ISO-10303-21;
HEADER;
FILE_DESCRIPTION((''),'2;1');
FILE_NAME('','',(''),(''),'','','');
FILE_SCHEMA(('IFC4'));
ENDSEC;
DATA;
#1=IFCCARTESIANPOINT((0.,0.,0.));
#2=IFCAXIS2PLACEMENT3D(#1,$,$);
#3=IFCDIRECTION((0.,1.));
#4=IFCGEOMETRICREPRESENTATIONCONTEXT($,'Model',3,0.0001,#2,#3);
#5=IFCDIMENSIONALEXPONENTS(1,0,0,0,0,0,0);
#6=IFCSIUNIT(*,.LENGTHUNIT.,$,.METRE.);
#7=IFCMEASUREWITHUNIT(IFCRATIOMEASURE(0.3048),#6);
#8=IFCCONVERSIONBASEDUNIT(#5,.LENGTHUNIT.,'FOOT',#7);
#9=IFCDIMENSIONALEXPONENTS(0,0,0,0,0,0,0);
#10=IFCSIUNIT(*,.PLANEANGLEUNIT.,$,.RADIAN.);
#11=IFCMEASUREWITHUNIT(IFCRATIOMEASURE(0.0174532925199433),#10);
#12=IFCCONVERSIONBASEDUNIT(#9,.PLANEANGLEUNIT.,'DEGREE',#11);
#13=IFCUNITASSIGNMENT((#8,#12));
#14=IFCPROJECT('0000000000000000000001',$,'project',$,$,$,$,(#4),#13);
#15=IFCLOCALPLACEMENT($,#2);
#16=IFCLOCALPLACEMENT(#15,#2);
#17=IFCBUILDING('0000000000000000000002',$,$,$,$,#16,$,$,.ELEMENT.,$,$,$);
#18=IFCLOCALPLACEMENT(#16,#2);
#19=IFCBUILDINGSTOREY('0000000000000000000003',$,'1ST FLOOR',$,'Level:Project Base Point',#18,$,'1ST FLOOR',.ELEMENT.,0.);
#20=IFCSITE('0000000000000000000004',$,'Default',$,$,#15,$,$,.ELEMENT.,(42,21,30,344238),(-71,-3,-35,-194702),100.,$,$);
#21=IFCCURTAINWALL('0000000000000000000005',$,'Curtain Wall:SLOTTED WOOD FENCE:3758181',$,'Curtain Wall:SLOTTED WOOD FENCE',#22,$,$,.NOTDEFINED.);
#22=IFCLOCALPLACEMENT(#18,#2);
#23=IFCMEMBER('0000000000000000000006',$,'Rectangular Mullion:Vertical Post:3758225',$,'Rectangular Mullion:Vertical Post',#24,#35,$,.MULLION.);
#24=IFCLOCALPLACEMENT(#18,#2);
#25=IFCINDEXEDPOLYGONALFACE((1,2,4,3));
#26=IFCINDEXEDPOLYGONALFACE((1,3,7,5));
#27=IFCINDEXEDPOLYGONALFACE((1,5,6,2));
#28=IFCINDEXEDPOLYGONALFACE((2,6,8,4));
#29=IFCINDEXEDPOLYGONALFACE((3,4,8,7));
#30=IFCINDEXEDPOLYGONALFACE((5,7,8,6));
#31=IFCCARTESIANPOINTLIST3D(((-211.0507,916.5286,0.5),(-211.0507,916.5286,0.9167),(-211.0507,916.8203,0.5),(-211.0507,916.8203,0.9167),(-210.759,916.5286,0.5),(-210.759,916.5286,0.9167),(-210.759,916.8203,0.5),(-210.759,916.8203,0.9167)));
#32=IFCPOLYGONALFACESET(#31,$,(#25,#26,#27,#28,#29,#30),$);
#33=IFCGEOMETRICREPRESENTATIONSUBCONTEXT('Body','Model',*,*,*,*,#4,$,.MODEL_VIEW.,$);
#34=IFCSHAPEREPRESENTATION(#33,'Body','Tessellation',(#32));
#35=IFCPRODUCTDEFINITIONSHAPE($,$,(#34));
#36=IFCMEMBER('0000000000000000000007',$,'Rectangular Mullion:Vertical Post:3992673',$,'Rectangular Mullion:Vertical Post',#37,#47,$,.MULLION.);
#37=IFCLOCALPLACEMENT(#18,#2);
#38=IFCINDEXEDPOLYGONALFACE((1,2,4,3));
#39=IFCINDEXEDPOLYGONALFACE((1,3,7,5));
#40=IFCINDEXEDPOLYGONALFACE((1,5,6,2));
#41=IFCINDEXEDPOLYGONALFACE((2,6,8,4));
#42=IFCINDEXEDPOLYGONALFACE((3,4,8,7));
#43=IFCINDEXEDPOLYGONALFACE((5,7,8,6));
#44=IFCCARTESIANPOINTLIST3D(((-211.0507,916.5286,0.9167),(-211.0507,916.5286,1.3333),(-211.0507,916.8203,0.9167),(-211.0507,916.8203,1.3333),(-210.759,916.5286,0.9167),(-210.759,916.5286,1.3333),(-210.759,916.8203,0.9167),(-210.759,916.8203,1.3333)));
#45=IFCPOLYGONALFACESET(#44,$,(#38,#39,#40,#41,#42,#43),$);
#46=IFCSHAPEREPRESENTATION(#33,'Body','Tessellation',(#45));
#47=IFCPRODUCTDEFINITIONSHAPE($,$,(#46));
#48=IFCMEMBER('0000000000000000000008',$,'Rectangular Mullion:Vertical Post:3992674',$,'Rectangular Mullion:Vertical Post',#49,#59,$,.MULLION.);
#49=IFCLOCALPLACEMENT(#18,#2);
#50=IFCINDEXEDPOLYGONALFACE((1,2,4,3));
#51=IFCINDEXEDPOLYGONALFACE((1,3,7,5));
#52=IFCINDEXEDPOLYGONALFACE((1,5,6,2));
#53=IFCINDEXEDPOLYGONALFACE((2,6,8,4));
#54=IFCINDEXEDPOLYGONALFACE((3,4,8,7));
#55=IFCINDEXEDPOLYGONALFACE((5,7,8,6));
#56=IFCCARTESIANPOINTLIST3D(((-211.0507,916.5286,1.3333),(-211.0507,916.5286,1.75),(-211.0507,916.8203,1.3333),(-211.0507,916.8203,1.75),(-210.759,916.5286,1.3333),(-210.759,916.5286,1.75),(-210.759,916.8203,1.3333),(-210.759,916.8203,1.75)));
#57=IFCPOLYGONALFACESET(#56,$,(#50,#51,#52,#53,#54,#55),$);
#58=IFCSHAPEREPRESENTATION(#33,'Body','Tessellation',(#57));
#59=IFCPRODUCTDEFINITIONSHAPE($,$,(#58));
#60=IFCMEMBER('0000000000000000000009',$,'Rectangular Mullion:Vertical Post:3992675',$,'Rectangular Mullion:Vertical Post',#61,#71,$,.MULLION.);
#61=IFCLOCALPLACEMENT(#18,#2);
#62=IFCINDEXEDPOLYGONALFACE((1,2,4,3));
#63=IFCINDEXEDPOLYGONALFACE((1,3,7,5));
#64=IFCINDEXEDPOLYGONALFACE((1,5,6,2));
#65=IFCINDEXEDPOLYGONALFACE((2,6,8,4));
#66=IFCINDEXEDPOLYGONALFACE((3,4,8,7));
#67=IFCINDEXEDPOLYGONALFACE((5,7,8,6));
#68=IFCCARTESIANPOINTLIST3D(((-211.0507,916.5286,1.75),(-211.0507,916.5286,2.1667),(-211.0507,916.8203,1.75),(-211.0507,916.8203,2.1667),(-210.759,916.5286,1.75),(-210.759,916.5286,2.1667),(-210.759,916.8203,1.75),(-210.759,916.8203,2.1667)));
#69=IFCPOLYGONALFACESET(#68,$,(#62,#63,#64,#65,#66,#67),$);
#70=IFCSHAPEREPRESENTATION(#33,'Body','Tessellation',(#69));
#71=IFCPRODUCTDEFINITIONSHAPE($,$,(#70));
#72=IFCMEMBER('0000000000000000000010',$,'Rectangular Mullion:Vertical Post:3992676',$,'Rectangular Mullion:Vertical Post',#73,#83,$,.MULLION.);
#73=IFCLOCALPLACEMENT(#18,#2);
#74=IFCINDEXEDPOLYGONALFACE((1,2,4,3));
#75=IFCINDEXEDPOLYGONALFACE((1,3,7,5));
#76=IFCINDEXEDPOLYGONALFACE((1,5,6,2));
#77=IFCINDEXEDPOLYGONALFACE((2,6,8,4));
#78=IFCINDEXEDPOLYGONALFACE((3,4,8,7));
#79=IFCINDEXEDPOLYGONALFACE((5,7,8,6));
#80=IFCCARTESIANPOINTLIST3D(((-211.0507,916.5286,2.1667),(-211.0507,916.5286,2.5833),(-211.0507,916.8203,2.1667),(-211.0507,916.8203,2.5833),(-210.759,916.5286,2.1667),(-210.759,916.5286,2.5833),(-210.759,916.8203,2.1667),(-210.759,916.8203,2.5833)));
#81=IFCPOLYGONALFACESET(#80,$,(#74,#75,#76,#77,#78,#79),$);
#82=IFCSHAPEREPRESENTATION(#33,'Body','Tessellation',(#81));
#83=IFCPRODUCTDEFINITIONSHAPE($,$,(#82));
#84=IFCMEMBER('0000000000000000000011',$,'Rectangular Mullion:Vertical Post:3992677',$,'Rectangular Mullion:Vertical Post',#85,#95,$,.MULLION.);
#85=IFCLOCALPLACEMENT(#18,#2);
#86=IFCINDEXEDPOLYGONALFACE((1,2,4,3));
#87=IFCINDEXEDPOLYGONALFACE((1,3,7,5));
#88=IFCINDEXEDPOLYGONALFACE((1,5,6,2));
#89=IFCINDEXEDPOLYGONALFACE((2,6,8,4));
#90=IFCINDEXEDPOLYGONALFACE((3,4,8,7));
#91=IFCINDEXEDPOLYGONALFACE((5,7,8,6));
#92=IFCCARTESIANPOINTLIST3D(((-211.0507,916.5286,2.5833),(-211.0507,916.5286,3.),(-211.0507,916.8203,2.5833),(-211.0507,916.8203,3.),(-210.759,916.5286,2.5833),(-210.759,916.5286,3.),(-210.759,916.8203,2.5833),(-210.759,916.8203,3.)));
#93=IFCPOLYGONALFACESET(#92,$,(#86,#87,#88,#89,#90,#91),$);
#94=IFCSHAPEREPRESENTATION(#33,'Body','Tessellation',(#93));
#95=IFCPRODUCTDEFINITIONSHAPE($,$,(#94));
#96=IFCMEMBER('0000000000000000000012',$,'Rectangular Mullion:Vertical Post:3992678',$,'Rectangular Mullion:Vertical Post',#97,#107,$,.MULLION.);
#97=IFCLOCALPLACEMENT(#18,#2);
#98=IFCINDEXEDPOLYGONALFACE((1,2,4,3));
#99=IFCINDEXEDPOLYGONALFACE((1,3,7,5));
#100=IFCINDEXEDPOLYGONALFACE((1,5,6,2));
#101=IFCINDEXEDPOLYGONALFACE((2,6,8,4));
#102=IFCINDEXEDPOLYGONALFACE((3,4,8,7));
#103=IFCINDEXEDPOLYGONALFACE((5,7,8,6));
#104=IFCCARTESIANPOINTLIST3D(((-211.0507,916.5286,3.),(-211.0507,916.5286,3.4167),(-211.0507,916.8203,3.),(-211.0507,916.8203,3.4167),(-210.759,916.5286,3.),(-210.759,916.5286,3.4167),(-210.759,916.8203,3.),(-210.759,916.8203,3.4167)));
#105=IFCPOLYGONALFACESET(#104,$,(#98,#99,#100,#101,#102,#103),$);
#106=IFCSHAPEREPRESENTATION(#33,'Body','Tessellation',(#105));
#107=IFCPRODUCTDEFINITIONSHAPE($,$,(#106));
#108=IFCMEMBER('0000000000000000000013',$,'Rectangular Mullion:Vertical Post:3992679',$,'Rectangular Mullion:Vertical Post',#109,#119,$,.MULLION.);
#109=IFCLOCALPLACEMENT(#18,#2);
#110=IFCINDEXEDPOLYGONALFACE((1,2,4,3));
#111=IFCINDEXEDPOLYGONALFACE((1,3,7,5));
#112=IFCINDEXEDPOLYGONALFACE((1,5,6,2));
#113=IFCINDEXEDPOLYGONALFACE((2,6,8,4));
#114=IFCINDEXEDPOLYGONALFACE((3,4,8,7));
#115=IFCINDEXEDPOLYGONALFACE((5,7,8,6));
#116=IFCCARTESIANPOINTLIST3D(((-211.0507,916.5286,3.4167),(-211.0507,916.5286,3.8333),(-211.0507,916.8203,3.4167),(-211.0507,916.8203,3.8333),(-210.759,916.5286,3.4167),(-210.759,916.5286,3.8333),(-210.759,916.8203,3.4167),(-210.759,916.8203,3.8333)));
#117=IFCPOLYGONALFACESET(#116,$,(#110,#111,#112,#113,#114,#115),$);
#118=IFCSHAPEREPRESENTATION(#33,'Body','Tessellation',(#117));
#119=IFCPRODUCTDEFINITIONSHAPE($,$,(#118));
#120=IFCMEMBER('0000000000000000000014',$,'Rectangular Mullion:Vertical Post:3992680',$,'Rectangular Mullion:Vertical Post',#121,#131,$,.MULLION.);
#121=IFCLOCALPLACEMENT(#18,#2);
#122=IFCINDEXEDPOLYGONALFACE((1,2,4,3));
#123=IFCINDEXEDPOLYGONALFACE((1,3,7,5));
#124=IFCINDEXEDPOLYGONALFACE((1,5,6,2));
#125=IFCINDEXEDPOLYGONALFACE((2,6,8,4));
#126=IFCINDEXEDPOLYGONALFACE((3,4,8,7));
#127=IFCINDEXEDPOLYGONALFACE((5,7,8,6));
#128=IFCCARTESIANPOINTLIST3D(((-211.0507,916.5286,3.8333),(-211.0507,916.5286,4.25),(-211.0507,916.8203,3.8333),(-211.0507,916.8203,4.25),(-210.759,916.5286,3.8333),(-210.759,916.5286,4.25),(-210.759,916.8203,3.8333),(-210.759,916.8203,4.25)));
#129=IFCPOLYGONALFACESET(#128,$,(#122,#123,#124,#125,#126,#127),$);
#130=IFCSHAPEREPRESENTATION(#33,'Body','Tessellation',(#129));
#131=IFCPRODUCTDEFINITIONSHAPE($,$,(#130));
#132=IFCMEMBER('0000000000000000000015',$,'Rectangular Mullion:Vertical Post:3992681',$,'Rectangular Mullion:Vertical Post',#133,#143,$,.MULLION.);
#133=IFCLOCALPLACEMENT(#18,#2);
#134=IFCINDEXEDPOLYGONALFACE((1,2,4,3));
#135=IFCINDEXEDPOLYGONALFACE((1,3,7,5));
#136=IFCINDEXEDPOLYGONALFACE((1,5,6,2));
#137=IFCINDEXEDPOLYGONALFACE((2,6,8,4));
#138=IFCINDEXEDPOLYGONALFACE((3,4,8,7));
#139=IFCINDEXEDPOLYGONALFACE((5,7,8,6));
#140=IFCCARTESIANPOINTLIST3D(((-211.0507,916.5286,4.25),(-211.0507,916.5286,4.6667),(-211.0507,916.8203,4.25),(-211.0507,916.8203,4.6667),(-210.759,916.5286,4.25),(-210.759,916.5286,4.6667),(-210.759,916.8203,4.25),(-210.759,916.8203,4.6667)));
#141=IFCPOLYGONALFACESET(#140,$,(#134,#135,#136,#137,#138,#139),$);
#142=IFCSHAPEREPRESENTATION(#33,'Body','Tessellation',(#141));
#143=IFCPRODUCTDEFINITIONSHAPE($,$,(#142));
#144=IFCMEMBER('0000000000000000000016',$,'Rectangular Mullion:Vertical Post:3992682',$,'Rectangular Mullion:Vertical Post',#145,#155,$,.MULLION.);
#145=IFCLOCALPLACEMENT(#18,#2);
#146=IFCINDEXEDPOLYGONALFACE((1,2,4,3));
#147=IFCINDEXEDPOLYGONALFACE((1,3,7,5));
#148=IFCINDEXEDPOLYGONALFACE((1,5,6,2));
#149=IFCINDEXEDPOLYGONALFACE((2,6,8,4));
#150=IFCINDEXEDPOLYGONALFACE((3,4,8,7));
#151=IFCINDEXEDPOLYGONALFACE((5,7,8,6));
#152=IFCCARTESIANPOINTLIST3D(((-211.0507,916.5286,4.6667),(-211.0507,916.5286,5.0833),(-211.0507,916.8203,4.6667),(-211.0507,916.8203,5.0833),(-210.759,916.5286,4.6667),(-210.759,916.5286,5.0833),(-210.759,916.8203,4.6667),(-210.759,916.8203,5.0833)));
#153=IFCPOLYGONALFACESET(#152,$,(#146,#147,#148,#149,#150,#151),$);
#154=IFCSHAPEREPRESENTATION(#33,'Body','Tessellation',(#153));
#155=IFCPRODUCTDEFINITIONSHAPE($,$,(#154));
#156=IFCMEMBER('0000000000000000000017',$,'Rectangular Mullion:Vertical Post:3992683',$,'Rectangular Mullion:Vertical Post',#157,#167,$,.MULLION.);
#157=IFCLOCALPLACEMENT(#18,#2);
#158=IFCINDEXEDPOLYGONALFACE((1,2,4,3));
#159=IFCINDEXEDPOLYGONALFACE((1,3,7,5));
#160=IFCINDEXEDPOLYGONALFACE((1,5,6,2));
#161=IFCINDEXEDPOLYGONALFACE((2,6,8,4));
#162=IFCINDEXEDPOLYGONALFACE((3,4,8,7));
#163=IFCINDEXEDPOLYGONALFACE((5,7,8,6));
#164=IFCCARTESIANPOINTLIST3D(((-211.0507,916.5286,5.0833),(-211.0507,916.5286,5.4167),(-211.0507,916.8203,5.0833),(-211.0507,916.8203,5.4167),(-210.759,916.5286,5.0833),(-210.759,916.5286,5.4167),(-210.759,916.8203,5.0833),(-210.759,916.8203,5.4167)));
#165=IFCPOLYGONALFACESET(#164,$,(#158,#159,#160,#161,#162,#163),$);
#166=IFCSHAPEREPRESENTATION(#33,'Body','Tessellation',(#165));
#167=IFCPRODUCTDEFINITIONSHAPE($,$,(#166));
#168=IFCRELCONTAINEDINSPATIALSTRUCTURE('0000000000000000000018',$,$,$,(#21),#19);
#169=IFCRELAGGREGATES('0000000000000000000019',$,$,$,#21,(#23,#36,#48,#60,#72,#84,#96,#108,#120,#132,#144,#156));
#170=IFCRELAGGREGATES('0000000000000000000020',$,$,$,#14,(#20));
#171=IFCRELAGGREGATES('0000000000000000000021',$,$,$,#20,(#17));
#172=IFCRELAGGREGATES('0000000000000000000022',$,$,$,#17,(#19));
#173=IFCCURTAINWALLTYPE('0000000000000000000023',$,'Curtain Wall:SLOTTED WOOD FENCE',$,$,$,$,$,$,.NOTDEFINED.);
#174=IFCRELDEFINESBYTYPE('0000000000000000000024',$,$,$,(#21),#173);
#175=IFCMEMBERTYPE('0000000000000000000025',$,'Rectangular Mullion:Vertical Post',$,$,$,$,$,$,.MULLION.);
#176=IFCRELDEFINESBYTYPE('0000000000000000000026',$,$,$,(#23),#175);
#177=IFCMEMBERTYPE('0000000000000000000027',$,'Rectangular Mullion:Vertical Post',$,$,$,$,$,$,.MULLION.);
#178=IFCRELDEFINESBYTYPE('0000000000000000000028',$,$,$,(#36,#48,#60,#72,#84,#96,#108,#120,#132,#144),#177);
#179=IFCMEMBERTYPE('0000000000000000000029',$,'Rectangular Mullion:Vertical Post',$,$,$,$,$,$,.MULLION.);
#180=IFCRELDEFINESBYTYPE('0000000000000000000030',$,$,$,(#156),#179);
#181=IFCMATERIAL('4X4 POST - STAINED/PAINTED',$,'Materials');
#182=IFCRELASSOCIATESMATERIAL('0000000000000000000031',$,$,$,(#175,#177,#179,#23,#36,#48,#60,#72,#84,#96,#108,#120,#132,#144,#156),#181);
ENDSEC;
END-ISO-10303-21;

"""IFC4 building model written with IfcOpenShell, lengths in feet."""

from ifc_helpers import new_model, entity, si_unit, converted_unit, direction, frame, origin, origin_2d_with_axis, place, context, subcontext, project, spatial, rectangle, extrude, source, transform, mapped, material, material_profile, profile_set, profile_usage, type_object, type_shapes, element, aggregate, save


model = new_model("IFC4")

# Units and contexts
model_context = context("Model", 3, precision=0.0001, world=origin(), true_north=direction((0.0, 1.0)))
body_context = subcontext(model_context, "Body", "Model", "MODEL_VIEW")
ifc_project = project(units=[converted_unit("LENGTHUNIT", "FOOT", entity("IfcRatioMeasure", 0.3048), si_unit("LENGTHUNIT", "METRE"), dimensions=[1, 0, 0, 0, 0, 0, 0]), converted_unit("PLANEANGLEUNIT", "DEGREE", entity("IfcRatioMeasure", 0.0174532925199433), si_unit("PLANEANGLEUNIT", "RADIAN"), dimensions=[0, 0, 0, 0, 0, 0, 0])], contexts=[model_context])

# Site, building, storey
site_placement = place(None, origin())
site = spatial("IfcSite", under=ifc_project, at=site_placement, Name="Default", CompositionType="ELEMENT", RefLatitude=(42, 21, 30, 344238), RefLongitude=(-71, -3, -35, -194702), RefElevation=100.0)
building_placement = place(site_placement, origin())
building = spatial("IfcBuilding", under=site, at=building_placement, CompositionType="ELEMENT")
storey_placement = place(building_placement, origin())
storey = spatial("IfcBuildingStorey", under=building, at=storey_placement, Name="1ST FLOOR", ObjectType="Level:Project Base Point", LongName="1ST FLOOR", CompositionType="ELEMENT", Elevation=0.0)

# Curtain wall, members
curtain_wall_type = type_object("IfcCurtainWallType", Name="Curtain Wall:SLOTTED WOOD FENCE", PredefinedType="NOTDEFINED")
curtain_wall_placement = place(storey_placement, origin())
curtain_wall = element("IfcCurtainWall", 1, at=curtain_wall_placement, inside=storey, type_object=curtain_wall_type, Name="Curtain Wall:SLOTTED WOOD FENCE:3758181", ObjectType="Curtain Wall:SLOTTED WOOD FENCE", PredefinedType="NOTDEFINED")
ifc_material_1 = material(Name="4X4 POST - STAINED/PAINTED", Category="Materials")
ifc_material_profile = material_profile(ifc_material_1, rectangle(XDim=0.2917, YDim=0.2917, at=origin_2d_with_axis()), Name="Vertical Post")
ifc_profile_set = profile_set([ifc_material_profile], Name="Vertical Post")
ifc_profile_usage_1 = profile_usage(ifc_profile_set)
member_type_1 = type_object("IfcMemberType", Name="Rectangular Mullion:Vertical Post", PredefinedType="MULLION", material=ifc_profile_set)
shared_shape_1 = source(origin(), body_context, "Body", "SweptSolid", [
    extrude(rectangle(XDim=0.2917, YDim=0.2917, at=origin_2d_with_axis()), frame((0.0, -0.2083, -0.4167), z_axis=(0.0, 0.0, 1.0), x_axis=(0.0, -1.0, 0.0)), (0.0, 0.0, 1.0), 0.4167),
])
type_shapes(member_type_1, [shared_shape_1])
member_1_placement = place(storey_placement, frame((-210.9048, 916.4661, 0.5), z_axis=(0.0, 0.0, -1.0), x_axis=(1.0, 0.0, 0.0)))
member_1 = element("IfcMember", 2, at=member_1_placement, type_object=member_type_1, material=ifc_profile_usage_1, Name="Rectangular Mullion:Vertical Post:3758225", ObjectType="Rectangular Mullion:Vertical Post", PredefinedType="MULLION", context=body_context, shape_type="MappedRepresentation", body=[
    mapped(shared_shape_1, transform((0.0, 0.0, 0.0), scale=1.0)),
])
ifc_profile_usage_2 = profile_usage(ifc_profile_set)
member_type_2 = type_object("IfcMemberType", Name="Rectangular Mullion:Vertical Post", PredefinedType="MULLION", material=ifc_profile_set)
shared_shape_2 = source(origin(), body_context, "Body", "SweptSolid", [
    extrude(rectangle(XDim=0.2917, YDim=0.2917, at=origin_2d_with_axis()), frame((0.0, -0.2083, -0.4167), z_axis=(0.0, 0.0, 1.0), x_axis=(0.0, -1.0, 0.0)), (0.0, 0.0, 1.0), 0.4167),
])
type_shapes(member_type_2, [shared_shape_2])
member_2_placement = place(storey_placement, frame((-210.9048, 916.4661, 0.9167), z_axis=(0.0, 0.0, -1.0), x_axis=(1.0, 0.0, 0.0)))
member_2 = element("IfcMember", 3, at=member_2_placement, type_object=member_type_2, material=ifc_profile_usage_2, Name="Rectangular Mullion:Vertical Post:3992673", ObjectType="Rectangular Mullion:Vertical Post", PredefinedType="MULLION", context=body_context, shape_type="MappedRepresentation", body=[
    mapped(shared_shape_2, transform((0.0, 0.0, 0.0), scale=1.0)),
])
ifc_profile_usage_3 = profile_usage(ifc_profile_set)
member_3_placement = place(storey_placement, frame((-210.9048, 916.4661, 1.3333), z_axis=(0.0, 0.0, -1.0), x_axis=(1.0, 0.0, 0.0)))
member_3 = element("IfcMember", 4, at=member_3_placement, type_object=member_type_2, material=ifc_profile_usage_3, Name="Rectangular Mullion:Vertical Post:3992674", ObjectType="Rectangular Mullion:Vertical Post", PredefinedType="MULLION", context=body_context, shape_type="MappedRepresentation", body=[
    mapped(shared_shape_2, transform((0.0, 0.0, 0.0), scale=1.0)),
])
ifc_profile_usage_4 = profile_usage(ifc_profile_set)
member_4_placement = place(storey_placement, frame((-210.9048, 916.4661, 1.75), z_axis=(0.0, 0.0, -1.0), x_axis=(1.0, 0.0, 0.0)))
member_4 = element("IfcMember", 5, at=member_4_placement, type_object=member_type_2, material=ifc_profile_usage_4, Name="Rectangular Mullion:Vertical Post:3992675", ObjectType="Rectangular Mullion:Vertical Post", PredefinedType="MULLION", context=body_context, shape_type="MappedRepresentation", body=[
    mapped(shared_shape_2, transform((0.0, 0.0, 0.0), scale=1.0)),
])
ifc_profile_usage_5 = profile_usage(ifc_profile_set)
member_5_placement = place(storey_placement, frame((-210.9048, 916.4661, 2.1667), z_axis=(0.0, 0.0, -1.0), x_axis=(1.0, 0.0, 0.0)))
member_5 = element("IfcMember", 6, at=member_5_placement, type_object=member_type_2, material=ifc_profile_usage_5, Name="Rectangular Mullion:Vertical Post:3992676", ObjectType="Rectangular Mullion:Vertical Post", PredefinedType="MULLION", context=body_context, shape_type="MappedRepresentation", body=[
    mapped(shared_shape_2, transform((0.0, 0.0, 0.0), scale=1.0)),
])
ifc_profile_usage_6 = profile_usage(ifc_profile_set)
member_6_placement = place(storey_placement, frame((-210.9048, 916.4661, 2.5833), z_axis=(0.0, 0.0, -1.0), x_axis=(1.0, 0.0, 0.0)))
member_6 = element("IfcMember", 7, at=member_6_placement, type_object=member_type_2, material=ifc_profile_usage_6, Name="Rectangular Mullion:Vertical Post:3992677", ObjectType="Rectangular Mullion:Vertical Post", PredefinedType="MULLION", context=body_context, shape_type="MappedRepresentation", body=[
    mapped(shared_shape_2, transform((0.0, 0.0, 0.0), scale=1.0)),
])
ifc_profile_usage_7 = profile_usage(ifc_profile_set)
member_7_placement = place(storey_placement, frame((-210.9048, 916.4661, 3.0), z_axis=(0.0, 0.0, -1.0), x_axis=(1.0, 0.0, 0.0)))
member_7 = element("IfcMember", 8, at=member_7_placement, type_object=member_type_2, material=ifc_profile_usage_7, Name="Rectangular Mullion:Vertical Post:3992678", ObjectType="Rectangular Mullion:Vertical Post", PredefinedType="MULLION", context=body_context, shape_type="MappedRepresentation", body=[
    mapped(shared_shape_2, transform((0.0, 0.0, 0.0), scale=1.0)),
])
ifc_profile_usage_8 = profile_usage(ifc_profile_set)
member_8_placement = place(storey_placement, frame((-210.9048, 916.4661, 3.4167), z_axis=(0.0, 0.0, -1.0), x_axis=(1.0, 0.0, 0.0)))
member_8 = element("IfcMember", 9, at=member_8_placement, type_object=member_type_2, material=ifc_profile_usage_8, Name="Rectangular Mullion:Vertical Post:3992679", ObjectType="Rectangular Mullion:Vertical Post", PredefinedType="MULLION", context=body_context, shape_type="MappedRepresentation", body=[
    mapped(shared_shape_2, transform((0.0, 0.0, 0.0), scale=1.0)),
])
ifc_profile_usage_9 = profile_usage(ifc_profile_set)
member_9_placement = place(storey_placement, frame((-210.9048, 916.4661, 3.8333), z_axis=(0.0, 0.0, -1.0), x_axis=(1.0, 0.0, 0.0)))
member_9 = element("IfcMember", 10, at=member_9_placement, type_object=member_type_2, material=ifc_profile_usage_9, Name="Rectangular Mullion:Vertical Post:3992680", ObjectType="Rectangular Mullion:Vertical Post", PredefinedType="MULLION", context=body_context, shape_type="MappedRepresentation", body=[
    mapped(shared_shape_2, transform((0.0, 0.0, 0.0), scale=1.0)),
])
ifc_profile_usage_10 = profile_usage(ifc_profile_set)
member_10_placement = place(storey_placement, frame((-210.9048, 916.4661, 4.25), z_axis=(0.0, 0.0, -1.0), x_axis=(1.0, 0.0, 0.0)))
member_10 = element("IfcMember", 11, at=member_10_placement, type_object=member_type_2, material=ifc_profile_usage_10, Name="Rectangular Mullion:Vertical Post:3992681", ObjectType="Rectangular Mullion:Vertical Post", PredefinedType="MULLION", context=body_context, shape_type="MappedRepresentation", body=[
    mapped(shared_shape_2, transform((0.0, 0.0, 0.0), scale=1.0)),
])
ifc_profile_usage_11 = profile_usage(ifc_profile_set)
member_11_placement = place(storey_placement, frame((-210.9048, 916.4661, 4.6667), z_axis=(0.0, 0.0, -1.0), x_axis=(1.0, 0.0, 0.0)))
member_11 = element("IfcMember", 12, at=member_11_placement, type_object=member_type_2, material=ifc_profile_usage_11, Name="Rectangular Mullion:Vertical Post:3992682", ObjectType="Rectangular Mullion:Vertical Post", PredefinedType="MULLION", context=body_context, shape_type="MappedRepresentation", body=[
    mapped(shared_shape_2, transform((0.0, 0.0, 0.0), scale=1.0)),
])
ifc_profile_usage_12 = profile_usage(ifc_profile_set)
member_type_3 = type_object("IfcMemberType", Name="Rectangular Mullion:Vertical Post", PredefinedType="MULLION", material=ifc_profile_set)
shared_shape_3 = source(origin(), body_context, "Body", "SweptSolid", [
    extrude(rectangle(XDim=0.2917, YDim=0.2917, at=origin_2d_with_axis()), frame((0.0, -0.2083, -0.3333), z_axis=(0.0, 0.0, 1.0), x_axis=(0.0, -1.0, 0.0)), (0.0, 0.0, 1.0), 0.3333),
])
type_shapes(member_type_3, [shared_shape_3])
member_12_placement = place(storey_placement, frame((-210.9048, 916.4661, 5.0833), z_axis=(0.0, 0.0, -1.0), x_axis=(1.0, 0.0, 0.0)))
member_12 = element("IfcMember", 13, at=member_12_placement, type_object=member_type_3, material=ifc_profile_usage_12, Name="Rectangular Mullion:Vertical Post:3992683", ObjectType="Rectangular Mullion:Vertical Post", PredefinedType="MULLION", context=body_context, shape_type="MappedRepresentation", body=[
    mapped(shared_shape_3, transform((0.0, 0.0, 0.0), scale=1.0)),
])
aggregate(curtain_wall, [member_1, member_2, member_3, member_4, member_5, member_6, member_7, member_8, member_9, member_10, member_11, member_12])

save(model, "model.ifc")
